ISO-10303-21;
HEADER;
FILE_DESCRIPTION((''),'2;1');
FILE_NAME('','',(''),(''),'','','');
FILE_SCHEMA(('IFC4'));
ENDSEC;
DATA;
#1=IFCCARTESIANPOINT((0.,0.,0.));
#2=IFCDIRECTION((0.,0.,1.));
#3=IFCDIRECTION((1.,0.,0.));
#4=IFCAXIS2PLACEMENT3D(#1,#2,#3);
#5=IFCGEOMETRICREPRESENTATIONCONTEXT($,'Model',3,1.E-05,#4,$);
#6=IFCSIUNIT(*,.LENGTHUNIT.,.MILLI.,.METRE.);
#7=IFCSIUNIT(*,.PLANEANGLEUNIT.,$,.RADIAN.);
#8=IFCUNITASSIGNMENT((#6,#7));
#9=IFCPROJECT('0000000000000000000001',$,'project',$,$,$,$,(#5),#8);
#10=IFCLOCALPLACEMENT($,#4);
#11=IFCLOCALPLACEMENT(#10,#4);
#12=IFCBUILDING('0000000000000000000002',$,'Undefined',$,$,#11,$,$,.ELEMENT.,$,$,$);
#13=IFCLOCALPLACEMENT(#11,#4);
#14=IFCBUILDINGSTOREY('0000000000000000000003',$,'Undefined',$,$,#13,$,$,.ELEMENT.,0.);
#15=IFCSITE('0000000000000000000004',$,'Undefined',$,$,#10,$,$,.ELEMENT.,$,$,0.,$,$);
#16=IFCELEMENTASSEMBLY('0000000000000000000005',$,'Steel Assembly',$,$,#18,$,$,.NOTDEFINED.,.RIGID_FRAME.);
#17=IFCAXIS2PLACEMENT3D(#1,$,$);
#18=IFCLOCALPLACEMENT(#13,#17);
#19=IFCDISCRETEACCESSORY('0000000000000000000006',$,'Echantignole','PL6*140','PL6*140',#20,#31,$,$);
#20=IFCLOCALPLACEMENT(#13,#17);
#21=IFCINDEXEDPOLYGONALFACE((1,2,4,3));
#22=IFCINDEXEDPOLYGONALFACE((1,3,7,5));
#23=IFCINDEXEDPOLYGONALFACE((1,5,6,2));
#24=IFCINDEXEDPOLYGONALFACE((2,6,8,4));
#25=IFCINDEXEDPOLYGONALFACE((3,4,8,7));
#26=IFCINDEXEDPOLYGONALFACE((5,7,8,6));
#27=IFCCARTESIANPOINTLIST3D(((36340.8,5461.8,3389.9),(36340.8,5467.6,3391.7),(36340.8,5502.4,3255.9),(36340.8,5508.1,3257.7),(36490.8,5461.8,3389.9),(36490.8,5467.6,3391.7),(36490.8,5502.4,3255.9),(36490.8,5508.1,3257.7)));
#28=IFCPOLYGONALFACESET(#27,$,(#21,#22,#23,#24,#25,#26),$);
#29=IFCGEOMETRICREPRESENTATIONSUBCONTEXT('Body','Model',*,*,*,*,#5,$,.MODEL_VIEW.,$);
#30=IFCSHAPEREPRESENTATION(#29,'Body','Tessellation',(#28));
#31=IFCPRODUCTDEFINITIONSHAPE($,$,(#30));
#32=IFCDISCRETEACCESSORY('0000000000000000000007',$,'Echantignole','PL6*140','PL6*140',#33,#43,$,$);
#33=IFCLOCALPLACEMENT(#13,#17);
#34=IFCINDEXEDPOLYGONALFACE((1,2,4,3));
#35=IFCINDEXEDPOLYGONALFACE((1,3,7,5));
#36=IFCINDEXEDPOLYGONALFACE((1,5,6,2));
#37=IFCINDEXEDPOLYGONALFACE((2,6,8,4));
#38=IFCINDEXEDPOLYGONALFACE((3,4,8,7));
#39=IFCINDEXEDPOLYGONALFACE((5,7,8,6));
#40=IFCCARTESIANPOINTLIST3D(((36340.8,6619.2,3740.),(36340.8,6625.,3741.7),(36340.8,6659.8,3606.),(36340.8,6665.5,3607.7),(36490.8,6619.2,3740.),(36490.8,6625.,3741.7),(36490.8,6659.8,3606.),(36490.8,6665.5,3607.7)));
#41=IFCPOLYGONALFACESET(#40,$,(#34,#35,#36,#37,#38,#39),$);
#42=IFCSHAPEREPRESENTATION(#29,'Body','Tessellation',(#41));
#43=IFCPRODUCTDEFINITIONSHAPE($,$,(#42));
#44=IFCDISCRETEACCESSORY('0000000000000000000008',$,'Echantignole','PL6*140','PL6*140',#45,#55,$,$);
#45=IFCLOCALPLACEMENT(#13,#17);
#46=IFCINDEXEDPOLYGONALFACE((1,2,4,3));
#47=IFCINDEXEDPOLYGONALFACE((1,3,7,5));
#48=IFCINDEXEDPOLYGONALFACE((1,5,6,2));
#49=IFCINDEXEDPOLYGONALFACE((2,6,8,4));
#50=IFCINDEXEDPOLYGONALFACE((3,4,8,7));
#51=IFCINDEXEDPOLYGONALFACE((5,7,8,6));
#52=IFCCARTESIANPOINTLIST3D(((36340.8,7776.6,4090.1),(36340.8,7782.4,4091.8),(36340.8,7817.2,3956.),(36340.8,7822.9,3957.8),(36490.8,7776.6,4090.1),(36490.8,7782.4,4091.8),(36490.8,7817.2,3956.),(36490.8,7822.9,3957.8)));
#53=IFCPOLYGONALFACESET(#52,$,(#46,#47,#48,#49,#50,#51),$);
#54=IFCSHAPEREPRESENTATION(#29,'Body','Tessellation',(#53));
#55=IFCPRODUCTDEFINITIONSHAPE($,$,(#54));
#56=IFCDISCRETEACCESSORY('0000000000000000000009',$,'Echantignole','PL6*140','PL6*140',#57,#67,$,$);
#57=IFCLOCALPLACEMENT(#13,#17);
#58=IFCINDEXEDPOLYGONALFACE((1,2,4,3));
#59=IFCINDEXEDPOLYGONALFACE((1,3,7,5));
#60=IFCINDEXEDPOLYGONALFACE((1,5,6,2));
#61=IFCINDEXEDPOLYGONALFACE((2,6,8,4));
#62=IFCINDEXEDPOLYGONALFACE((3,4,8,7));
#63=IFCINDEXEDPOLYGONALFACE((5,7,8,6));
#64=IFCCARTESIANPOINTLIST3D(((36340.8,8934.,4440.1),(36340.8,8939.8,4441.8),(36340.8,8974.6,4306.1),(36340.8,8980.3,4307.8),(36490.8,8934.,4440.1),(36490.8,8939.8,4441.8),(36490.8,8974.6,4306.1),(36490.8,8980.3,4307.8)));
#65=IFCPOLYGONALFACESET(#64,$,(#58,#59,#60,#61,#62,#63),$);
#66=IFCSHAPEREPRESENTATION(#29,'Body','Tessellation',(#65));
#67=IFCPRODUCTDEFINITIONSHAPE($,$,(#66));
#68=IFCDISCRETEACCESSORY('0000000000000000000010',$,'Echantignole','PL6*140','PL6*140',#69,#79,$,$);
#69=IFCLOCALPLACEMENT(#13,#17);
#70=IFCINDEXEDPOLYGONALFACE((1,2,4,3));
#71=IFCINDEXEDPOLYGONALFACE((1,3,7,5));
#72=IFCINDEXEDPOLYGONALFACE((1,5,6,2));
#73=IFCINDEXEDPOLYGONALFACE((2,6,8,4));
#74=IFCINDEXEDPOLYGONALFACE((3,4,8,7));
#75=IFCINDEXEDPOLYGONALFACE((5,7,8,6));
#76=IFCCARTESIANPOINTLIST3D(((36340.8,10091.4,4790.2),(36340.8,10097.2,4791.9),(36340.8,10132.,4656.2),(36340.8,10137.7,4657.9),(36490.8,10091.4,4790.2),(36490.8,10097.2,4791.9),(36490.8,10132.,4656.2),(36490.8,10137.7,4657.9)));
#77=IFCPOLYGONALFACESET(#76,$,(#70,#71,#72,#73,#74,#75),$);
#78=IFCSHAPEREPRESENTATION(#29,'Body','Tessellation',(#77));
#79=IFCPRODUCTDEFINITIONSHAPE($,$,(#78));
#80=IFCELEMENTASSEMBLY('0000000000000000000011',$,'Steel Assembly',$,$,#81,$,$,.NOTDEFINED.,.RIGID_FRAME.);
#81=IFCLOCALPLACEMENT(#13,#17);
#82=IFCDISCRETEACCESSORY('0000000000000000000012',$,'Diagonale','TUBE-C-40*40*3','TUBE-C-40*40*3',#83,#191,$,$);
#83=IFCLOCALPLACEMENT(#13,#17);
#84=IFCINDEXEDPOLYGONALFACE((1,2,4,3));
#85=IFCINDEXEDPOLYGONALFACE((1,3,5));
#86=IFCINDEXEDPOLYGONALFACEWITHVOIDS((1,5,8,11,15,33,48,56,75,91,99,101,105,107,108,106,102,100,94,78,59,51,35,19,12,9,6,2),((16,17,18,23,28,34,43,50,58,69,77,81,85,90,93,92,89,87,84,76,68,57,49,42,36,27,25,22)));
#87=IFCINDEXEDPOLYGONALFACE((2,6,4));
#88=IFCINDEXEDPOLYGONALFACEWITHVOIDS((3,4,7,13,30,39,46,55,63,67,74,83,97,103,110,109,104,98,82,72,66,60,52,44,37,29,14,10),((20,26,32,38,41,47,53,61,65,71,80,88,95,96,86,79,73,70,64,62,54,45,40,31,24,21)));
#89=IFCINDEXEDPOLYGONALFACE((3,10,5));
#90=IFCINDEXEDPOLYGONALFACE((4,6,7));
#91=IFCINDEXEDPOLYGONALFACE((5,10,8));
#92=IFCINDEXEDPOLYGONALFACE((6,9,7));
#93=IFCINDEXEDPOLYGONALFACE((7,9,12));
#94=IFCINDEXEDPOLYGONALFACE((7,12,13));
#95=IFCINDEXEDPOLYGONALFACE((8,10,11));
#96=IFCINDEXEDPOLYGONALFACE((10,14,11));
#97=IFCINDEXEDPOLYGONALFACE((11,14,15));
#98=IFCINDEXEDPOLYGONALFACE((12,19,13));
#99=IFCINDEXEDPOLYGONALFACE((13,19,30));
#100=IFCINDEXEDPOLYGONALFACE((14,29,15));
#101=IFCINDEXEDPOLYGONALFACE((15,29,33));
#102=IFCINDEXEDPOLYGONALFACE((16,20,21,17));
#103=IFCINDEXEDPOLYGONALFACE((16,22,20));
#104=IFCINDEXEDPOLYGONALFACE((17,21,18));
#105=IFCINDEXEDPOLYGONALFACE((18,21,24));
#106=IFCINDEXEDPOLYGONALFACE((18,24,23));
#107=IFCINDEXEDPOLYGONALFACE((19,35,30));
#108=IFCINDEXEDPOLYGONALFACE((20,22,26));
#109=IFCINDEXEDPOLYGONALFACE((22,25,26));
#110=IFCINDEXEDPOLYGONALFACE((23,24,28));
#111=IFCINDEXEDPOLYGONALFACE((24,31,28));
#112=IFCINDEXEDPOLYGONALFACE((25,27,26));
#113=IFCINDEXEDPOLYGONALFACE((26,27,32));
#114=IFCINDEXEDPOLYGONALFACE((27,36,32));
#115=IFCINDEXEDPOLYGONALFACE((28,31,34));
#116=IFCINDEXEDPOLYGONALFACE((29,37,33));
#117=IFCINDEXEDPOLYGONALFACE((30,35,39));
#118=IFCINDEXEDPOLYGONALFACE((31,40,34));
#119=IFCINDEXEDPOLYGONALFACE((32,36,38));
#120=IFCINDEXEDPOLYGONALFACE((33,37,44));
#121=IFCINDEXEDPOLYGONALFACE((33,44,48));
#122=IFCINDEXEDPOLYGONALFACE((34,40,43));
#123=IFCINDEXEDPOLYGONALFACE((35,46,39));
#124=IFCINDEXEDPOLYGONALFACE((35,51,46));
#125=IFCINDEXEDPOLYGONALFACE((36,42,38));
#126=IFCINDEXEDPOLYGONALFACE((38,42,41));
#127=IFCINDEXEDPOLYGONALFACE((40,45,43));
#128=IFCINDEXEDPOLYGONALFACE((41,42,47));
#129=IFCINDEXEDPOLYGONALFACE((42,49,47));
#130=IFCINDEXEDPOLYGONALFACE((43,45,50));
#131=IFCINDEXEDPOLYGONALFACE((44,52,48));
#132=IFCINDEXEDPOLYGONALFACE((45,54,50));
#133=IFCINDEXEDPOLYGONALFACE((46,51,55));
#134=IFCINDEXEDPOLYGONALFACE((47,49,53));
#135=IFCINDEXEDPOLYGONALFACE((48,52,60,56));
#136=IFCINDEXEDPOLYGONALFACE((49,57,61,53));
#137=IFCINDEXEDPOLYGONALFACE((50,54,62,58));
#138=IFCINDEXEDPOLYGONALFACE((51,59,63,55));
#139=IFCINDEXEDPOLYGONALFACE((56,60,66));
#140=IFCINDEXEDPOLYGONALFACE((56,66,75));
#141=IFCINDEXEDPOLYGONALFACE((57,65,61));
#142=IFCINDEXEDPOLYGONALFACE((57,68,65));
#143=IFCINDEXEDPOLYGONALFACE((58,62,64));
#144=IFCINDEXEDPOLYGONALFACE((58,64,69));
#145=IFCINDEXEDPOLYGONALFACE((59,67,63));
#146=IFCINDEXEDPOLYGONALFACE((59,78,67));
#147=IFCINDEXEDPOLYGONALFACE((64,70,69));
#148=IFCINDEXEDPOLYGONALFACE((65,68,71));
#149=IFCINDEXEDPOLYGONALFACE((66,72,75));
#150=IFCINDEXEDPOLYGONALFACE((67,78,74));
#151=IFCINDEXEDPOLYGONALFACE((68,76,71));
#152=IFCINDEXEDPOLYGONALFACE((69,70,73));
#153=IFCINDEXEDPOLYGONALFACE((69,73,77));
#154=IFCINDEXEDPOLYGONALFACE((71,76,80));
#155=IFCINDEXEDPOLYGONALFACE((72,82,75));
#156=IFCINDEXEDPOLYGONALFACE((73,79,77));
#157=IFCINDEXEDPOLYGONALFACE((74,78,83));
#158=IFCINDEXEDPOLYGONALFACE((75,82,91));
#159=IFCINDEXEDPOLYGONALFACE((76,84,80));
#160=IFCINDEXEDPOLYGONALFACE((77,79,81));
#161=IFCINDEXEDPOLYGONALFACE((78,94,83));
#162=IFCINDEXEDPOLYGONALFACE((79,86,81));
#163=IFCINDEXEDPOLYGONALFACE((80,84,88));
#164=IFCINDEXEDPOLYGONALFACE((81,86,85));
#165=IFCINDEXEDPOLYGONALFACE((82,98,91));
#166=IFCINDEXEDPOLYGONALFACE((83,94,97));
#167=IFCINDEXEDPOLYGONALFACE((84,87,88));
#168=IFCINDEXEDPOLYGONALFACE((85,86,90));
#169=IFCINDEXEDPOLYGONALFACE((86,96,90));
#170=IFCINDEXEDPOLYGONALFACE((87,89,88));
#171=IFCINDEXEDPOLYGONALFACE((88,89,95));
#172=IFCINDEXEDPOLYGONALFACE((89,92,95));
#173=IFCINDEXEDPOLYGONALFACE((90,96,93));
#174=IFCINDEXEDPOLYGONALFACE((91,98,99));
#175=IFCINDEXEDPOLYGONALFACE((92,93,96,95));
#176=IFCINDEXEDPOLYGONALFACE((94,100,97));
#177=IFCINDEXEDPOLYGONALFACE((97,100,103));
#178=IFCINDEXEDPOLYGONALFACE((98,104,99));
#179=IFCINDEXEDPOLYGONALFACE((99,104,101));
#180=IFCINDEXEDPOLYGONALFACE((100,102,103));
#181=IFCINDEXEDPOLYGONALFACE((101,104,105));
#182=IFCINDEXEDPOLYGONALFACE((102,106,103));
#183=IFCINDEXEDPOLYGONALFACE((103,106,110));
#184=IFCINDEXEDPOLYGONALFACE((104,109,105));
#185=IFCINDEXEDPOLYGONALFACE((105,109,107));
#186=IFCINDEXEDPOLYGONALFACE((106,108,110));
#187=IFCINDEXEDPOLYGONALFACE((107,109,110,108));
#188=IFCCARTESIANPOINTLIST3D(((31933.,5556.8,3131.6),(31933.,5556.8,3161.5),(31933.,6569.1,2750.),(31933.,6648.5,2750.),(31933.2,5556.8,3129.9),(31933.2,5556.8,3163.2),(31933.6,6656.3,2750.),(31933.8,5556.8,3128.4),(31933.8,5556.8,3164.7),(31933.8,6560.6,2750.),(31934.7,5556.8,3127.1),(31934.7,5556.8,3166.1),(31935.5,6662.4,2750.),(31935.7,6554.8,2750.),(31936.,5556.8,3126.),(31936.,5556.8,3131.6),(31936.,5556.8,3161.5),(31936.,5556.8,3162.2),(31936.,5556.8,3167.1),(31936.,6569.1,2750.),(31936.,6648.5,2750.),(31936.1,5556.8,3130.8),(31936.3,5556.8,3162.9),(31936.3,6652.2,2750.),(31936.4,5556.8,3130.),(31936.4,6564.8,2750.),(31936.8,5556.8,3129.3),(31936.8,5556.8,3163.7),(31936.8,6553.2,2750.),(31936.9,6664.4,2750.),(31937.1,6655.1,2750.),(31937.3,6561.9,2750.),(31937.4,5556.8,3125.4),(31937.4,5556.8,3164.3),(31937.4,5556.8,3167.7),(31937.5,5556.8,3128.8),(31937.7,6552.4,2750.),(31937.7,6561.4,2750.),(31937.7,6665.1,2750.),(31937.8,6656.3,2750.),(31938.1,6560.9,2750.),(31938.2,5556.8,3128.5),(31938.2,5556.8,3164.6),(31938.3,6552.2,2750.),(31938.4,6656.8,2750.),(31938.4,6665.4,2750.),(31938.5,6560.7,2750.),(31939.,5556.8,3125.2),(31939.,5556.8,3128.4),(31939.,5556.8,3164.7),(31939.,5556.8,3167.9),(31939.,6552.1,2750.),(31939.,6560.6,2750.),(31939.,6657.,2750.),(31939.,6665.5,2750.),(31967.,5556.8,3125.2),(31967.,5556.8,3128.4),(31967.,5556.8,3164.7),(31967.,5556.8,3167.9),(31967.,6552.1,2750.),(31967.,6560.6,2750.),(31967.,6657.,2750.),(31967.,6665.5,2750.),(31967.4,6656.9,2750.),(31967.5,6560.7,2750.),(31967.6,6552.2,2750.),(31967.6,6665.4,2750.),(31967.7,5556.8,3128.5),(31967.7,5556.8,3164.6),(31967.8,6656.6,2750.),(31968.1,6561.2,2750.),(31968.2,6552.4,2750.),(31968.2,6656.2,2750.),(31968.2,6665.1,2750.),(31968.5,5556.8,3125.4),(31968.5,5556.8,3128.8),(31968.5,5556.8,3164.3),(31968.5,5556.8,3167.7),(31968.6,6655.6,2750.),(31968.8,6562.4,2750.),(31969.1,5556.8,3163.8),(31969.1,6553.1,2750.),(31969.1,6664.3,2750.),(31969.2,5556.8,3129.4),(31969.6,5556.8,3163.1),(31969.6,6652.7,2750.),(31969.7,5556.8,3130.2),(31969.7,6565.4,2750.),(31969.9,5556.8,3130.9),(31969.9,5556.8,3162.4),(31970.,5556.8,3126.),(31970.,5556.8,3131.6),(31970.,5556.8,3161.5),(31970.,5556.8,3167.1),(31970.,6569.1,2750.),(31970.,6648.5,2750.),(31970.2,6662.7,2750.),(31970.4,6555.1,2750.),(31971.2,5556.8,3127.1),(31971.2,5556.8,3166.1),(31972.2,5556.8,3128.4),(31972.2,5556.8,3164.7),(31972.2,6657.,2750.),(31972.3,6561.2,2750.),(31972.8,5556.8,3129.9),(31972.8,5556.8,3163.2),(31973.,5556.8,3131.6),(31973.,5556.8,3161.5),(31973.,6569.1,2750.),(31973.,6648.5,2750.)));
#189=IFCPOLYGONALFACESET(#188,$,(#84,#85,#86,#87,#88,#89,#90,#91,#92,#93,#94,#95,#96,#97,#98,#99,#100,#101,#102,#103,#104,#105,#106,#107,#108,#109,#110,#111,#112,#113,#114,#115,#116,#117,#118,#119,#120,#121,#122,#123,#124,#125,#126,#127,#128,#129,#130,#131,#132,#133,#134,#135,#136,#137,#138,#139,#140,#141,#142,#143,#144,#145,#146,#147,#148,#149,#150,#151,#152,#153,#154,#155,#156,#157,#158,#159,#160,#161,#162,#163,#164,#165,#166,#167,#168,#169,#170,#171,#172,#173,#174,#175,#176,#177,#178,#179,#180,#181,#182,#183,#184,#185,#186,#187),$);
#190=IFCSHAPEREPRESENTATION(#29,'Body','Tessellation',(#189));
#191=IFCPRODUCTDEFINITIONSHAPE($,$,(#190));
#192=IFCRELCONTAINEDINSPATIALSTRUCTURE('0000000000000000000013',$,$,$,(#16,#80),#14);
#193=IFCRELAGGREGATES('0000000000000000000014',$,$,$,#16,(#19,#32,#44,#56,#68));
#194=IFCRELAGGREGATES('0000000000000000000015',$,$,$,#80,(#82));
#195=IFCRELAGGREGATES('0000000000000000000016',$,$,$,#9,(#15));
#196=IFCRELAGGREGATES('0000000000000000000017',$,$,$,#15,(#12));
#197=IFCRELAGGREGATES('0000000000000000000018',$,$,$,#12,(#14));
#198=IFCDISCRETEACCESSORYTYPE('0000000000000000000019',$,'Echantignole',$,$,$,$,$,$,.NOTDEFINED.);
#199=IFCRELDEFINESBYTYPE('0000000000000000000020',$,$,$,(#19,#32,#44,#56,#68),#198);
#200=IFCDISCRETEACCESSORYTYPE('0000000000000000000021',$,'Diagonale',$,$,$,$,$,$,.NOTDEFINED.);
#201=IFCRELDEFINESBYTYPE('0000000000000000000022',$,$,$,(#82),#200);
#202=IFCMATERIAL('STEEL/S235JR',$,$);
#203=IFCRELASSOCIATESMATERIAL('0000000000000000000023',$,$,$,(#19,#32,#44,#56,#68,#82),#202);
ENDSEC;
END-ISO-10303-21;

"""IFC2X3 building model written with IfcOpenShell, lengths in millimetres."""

from ifc_helpers import new_model, si_unit, frame, origin_with_axes, origin_2d_with_axis, place, context, subcontext, project, spatial, polyline, hollow_rectangle, outline, extrude, clip, halfspace, material, type_object, element, aggregate, save


model = new_model("IFC2X3")

# Units and contexts
model_context = context("Model", 3, precision=1e-05, world=origin_with_axes())
body_context = subcontext(model_context, "Body", "Model", "MODEL_VIEW")
ifc_project = project(units=[si_unit("LENGTHUNIT", "METRE", prefix="MILLI"), si_unit("PLANEANGLEUNIT", "RADIAN")], contexts=[model_context])

# Site, building, storey
site_placement = place(None, origin_with_axes())
site = spatial("IfcSite", under=ifc_project, at=site_placement, Name="Undefined", CompositionType="ELEMENT", RefElevation=0.0)
building_placement = place(site_placement, origin_with_axes())
building = spatial("IfcBuilding", under=site, at=building_placement, Name="Undefined", CompositionType="ELEMENT")
storey_placement = place(building_placement, origin_with_axes())
storey = spatial("IfcBuildingStorey", under=building, at=storey_placement, Name="Undefined", CompositionType="ELEMENT", Elevation=0.0)

# Element assemblies, discrete accessories
assembly_1_placement = place(storey_placement, origin_with_axes())
assembly_1 = element("IfcElementAssembly", 1, at=assembly_1_placement, inside=storey, Name="Steel Assembly", AssemblyPlace="NOTDEFINED", PredefinedType="RIGID_FRAME")
ifc_material_1 = material(Name="STEEL/S235JR")
discrete_accessory_type_1 = type_object("IfcDiscreteAccessoryType", Name="Echantignole")
discrete_accessory_1_placement = place(assembly_1_placement, frame((36340.8, 5485.0, 3323.8), z_axis=(0.0, -0.957179, -0.289497), x_axis=(1.0, 0.0, 0.0)))
discrete_accessory_1 = element("IfcDiscreteAccessory", 2, at=discrete_accessory_1_placement, type_object=discrete_accessory_type_1, material=ifc_material_1, Name="Echantignole", Description="PL6*140", ObjectType="PL6*140", context=body_context, shape_type="SweptSolid", body=[
    extrude(outline(polyline([(150.0, 70.0), (150.0, -70.0), (0.0, -70.0), (0.0, 70.0), (150.0, 70.0)])), frame((0.0, 0.0, -3.0), z_axis=(0.0, 0.0, 1.0), x_axis=(1.0, 0.0, 0.0)), (0.0, 0.0, 1.0), 6.0),
])
discrete_accessory_2_placement = place(assembly_1_placement, frame((36340.8, 6642.4, 3673.9), z_axis=(0.0, -0.957179, -0.289497), x_axis=(1.0, 0.0, 0.0)))
discrete_accessory_2 = element("IfcDiscreteAccessory", 3, at=discrete_accessory_2_placement, type_object=discrete_accessory_type_1, material=ifc_material_1, Name="Echantignole", Description="PL6*140", ObjectType="PL6*140", context=body_context, shape_type="SweptSolid", body=[
    extrude(outline(polyline([(150.0, 70.0), (150.0, -70.0), (0.0, -70.0), (0.0, 70.0), (150.0, 70.0)])), frame((0.0, 0.0, -3.0), z_axis=(0.0, 0.0, 1.0), x_axis=(1.0, 0.0, 0.0)), (0.0, 0.0, 1.0), 6.0),
])
discrete_accessory_3_placement = place(assembly_1_placement, frame((36340.8, 7799.8, 4023.9), z_axis=(0.0, -0.957179, -0.289497), x_axis=(1.0, 0.0, 0.0)))
discrete_accessory_3 = element("IfcDiscreteAccessory", 4, at=discrete_accessory_3_placement, type_object=discrete_accessory_type_1, material=ifc_material_1, Name="Echantignole", Description="PL6*140", ObjectType="PL6*140", context=body_context, shape_type="SweptSolid", body=[
    extrude(outline(polyline([(150.0, 70.0), (150.0, -70.0), (0.0, -70.0), (0.0, 70.0), (150.0, 70.0)])), frame((0.0, 0.0, -3.0), z_axis=(0.0, 0.0, 1.0), x_axis=(1.0, 0.0, 0.0)), (0.0, 0.0, 1.0), 6.0),
])
discrete_accessory_4_placement = place(assembly_1_placement, frame((36340.8, 8957.2, 4374.0), z_axis=(0.0, -0.957179, -0.289497), x_axis=(1.0, 0.0, 0.0)))
discrete_accessory_4 = element("IfcDiscreteAccessory", 5, at=discrete_accessory_4_placement, type_object=discrete_accessory_type_1, material=ifc_material_1, Name="Echantignole", Description="PL6*140", ObjectType="PL6*140", context=body_context, shape_type="SweptSolid", body=[
    extrude(outline(polyline([(150.0, 70.0), (150.0, -70.0), (0.0, -70.0), (0.0, 70.0), (150.0, 70.0)])), frame((0.0, 0.0, -3.0), z_axis=(0.0, 0.0, 1.0), x_axis=(1.0, 0.0, 0.0)), (0.0, 0.0, 1.0), 6.0),
])
discrete_accessory_5_placement = place(assembly_1_placement, frame((36340.8, 10114.6, 4724.0), z_axis=(0.0, -0.957179, -0.289497), x_axis=(1.0, 0.0, 0.0)))
discrete_accessory_5 = element("IfcDiscreteAccessory", 6, at=discrete_accessory_5_placement, type_object=discrete_accessory_type_1, material=ifc_material_1, Name="Echantignole", Description="PL6*140", ObjectType="PL6*140", context=body_context, shape_type="SweptSolid", body=[
    extrude(outline(polyline([(150.0, 70.0), (150.0, -70.0), (0.0, -70.0), (0.0, 70.0), (150.0, 70.0)])), frame((0.0, 0.0, -3.0), z_axis=(0.0, 0.0, 1.0), x_axis=(1.0, 0.0, 0.0)), (0.0, 0.0, 1.0), 6.0),
])
aggregate(assembly_1, [discrete_accessory_1, discrete_accessory_2, discrete_accessory_3, discrete_accessory_4, discrete_accessory_5])
assembly_2_placement = place(storey_placement, origin_with_axes())
assembly_2 = element("IfcElementAssembly", 7, at=assembly_2_placement, inside=storey, Name="Steel Assembly", AssemblyPlace="NOTDEFINED", PredefinedType="RIGID_FRAME")
discrete_accessory_type_2 = type_object("IfcDiscreteAccessoryType", Name="Diagonale")
discrete_accessory_6_placement = place(assembly_2_placement, frame((31953.0, 6658.4, 2731.3), z_axis=(0.0, 0.352745, 0.93572), x_axis=(0.0, -0.93572, 0.352745)))
discrete_accessory_6 = element("IfcDiscreteAccessory", 8, at=discrete_accessory_6_placement, type_object=discrete_accessory_type_2, material=ifc_material_1, Name="Diagonale", Description="TUBE-C-40*40*3", ObjectType="TUBE-C-40*40*3", context=body_context, shape_type="Clipping", body=[
    clip(clip(extrude(hollow_rectangle(XDim=40.0, YDim=40.0, WallThickness=3.0, InnerFilletRadius=3.0, OuterFilletRadius=6.0, at=origin_2d_with_axis()), frame((1238.5, 0.0, 0.0), z_axis=(-1.0, 0.0, 0.0), x_axis=(0.0, -1.0, 0.0)), (0.0, 0.0, 1.0), 1246.6), halfspace(frame((1146.9, 0.0, -80.5), z_axis=(0.93572, 0.0, -0.352745), x_axis=(0.352745, 0.0, 0.93572)), False)), halfspace(frame((172.4, 0.0, -45.0), z_axis=(0.352745, 0.0, 0.93572), x_axis=(-0.93572, 0.0, 0.352745)), True)),
])
aggregate(assembly_2, [discrete_accessory_6])

save(model, "model.ifc")
